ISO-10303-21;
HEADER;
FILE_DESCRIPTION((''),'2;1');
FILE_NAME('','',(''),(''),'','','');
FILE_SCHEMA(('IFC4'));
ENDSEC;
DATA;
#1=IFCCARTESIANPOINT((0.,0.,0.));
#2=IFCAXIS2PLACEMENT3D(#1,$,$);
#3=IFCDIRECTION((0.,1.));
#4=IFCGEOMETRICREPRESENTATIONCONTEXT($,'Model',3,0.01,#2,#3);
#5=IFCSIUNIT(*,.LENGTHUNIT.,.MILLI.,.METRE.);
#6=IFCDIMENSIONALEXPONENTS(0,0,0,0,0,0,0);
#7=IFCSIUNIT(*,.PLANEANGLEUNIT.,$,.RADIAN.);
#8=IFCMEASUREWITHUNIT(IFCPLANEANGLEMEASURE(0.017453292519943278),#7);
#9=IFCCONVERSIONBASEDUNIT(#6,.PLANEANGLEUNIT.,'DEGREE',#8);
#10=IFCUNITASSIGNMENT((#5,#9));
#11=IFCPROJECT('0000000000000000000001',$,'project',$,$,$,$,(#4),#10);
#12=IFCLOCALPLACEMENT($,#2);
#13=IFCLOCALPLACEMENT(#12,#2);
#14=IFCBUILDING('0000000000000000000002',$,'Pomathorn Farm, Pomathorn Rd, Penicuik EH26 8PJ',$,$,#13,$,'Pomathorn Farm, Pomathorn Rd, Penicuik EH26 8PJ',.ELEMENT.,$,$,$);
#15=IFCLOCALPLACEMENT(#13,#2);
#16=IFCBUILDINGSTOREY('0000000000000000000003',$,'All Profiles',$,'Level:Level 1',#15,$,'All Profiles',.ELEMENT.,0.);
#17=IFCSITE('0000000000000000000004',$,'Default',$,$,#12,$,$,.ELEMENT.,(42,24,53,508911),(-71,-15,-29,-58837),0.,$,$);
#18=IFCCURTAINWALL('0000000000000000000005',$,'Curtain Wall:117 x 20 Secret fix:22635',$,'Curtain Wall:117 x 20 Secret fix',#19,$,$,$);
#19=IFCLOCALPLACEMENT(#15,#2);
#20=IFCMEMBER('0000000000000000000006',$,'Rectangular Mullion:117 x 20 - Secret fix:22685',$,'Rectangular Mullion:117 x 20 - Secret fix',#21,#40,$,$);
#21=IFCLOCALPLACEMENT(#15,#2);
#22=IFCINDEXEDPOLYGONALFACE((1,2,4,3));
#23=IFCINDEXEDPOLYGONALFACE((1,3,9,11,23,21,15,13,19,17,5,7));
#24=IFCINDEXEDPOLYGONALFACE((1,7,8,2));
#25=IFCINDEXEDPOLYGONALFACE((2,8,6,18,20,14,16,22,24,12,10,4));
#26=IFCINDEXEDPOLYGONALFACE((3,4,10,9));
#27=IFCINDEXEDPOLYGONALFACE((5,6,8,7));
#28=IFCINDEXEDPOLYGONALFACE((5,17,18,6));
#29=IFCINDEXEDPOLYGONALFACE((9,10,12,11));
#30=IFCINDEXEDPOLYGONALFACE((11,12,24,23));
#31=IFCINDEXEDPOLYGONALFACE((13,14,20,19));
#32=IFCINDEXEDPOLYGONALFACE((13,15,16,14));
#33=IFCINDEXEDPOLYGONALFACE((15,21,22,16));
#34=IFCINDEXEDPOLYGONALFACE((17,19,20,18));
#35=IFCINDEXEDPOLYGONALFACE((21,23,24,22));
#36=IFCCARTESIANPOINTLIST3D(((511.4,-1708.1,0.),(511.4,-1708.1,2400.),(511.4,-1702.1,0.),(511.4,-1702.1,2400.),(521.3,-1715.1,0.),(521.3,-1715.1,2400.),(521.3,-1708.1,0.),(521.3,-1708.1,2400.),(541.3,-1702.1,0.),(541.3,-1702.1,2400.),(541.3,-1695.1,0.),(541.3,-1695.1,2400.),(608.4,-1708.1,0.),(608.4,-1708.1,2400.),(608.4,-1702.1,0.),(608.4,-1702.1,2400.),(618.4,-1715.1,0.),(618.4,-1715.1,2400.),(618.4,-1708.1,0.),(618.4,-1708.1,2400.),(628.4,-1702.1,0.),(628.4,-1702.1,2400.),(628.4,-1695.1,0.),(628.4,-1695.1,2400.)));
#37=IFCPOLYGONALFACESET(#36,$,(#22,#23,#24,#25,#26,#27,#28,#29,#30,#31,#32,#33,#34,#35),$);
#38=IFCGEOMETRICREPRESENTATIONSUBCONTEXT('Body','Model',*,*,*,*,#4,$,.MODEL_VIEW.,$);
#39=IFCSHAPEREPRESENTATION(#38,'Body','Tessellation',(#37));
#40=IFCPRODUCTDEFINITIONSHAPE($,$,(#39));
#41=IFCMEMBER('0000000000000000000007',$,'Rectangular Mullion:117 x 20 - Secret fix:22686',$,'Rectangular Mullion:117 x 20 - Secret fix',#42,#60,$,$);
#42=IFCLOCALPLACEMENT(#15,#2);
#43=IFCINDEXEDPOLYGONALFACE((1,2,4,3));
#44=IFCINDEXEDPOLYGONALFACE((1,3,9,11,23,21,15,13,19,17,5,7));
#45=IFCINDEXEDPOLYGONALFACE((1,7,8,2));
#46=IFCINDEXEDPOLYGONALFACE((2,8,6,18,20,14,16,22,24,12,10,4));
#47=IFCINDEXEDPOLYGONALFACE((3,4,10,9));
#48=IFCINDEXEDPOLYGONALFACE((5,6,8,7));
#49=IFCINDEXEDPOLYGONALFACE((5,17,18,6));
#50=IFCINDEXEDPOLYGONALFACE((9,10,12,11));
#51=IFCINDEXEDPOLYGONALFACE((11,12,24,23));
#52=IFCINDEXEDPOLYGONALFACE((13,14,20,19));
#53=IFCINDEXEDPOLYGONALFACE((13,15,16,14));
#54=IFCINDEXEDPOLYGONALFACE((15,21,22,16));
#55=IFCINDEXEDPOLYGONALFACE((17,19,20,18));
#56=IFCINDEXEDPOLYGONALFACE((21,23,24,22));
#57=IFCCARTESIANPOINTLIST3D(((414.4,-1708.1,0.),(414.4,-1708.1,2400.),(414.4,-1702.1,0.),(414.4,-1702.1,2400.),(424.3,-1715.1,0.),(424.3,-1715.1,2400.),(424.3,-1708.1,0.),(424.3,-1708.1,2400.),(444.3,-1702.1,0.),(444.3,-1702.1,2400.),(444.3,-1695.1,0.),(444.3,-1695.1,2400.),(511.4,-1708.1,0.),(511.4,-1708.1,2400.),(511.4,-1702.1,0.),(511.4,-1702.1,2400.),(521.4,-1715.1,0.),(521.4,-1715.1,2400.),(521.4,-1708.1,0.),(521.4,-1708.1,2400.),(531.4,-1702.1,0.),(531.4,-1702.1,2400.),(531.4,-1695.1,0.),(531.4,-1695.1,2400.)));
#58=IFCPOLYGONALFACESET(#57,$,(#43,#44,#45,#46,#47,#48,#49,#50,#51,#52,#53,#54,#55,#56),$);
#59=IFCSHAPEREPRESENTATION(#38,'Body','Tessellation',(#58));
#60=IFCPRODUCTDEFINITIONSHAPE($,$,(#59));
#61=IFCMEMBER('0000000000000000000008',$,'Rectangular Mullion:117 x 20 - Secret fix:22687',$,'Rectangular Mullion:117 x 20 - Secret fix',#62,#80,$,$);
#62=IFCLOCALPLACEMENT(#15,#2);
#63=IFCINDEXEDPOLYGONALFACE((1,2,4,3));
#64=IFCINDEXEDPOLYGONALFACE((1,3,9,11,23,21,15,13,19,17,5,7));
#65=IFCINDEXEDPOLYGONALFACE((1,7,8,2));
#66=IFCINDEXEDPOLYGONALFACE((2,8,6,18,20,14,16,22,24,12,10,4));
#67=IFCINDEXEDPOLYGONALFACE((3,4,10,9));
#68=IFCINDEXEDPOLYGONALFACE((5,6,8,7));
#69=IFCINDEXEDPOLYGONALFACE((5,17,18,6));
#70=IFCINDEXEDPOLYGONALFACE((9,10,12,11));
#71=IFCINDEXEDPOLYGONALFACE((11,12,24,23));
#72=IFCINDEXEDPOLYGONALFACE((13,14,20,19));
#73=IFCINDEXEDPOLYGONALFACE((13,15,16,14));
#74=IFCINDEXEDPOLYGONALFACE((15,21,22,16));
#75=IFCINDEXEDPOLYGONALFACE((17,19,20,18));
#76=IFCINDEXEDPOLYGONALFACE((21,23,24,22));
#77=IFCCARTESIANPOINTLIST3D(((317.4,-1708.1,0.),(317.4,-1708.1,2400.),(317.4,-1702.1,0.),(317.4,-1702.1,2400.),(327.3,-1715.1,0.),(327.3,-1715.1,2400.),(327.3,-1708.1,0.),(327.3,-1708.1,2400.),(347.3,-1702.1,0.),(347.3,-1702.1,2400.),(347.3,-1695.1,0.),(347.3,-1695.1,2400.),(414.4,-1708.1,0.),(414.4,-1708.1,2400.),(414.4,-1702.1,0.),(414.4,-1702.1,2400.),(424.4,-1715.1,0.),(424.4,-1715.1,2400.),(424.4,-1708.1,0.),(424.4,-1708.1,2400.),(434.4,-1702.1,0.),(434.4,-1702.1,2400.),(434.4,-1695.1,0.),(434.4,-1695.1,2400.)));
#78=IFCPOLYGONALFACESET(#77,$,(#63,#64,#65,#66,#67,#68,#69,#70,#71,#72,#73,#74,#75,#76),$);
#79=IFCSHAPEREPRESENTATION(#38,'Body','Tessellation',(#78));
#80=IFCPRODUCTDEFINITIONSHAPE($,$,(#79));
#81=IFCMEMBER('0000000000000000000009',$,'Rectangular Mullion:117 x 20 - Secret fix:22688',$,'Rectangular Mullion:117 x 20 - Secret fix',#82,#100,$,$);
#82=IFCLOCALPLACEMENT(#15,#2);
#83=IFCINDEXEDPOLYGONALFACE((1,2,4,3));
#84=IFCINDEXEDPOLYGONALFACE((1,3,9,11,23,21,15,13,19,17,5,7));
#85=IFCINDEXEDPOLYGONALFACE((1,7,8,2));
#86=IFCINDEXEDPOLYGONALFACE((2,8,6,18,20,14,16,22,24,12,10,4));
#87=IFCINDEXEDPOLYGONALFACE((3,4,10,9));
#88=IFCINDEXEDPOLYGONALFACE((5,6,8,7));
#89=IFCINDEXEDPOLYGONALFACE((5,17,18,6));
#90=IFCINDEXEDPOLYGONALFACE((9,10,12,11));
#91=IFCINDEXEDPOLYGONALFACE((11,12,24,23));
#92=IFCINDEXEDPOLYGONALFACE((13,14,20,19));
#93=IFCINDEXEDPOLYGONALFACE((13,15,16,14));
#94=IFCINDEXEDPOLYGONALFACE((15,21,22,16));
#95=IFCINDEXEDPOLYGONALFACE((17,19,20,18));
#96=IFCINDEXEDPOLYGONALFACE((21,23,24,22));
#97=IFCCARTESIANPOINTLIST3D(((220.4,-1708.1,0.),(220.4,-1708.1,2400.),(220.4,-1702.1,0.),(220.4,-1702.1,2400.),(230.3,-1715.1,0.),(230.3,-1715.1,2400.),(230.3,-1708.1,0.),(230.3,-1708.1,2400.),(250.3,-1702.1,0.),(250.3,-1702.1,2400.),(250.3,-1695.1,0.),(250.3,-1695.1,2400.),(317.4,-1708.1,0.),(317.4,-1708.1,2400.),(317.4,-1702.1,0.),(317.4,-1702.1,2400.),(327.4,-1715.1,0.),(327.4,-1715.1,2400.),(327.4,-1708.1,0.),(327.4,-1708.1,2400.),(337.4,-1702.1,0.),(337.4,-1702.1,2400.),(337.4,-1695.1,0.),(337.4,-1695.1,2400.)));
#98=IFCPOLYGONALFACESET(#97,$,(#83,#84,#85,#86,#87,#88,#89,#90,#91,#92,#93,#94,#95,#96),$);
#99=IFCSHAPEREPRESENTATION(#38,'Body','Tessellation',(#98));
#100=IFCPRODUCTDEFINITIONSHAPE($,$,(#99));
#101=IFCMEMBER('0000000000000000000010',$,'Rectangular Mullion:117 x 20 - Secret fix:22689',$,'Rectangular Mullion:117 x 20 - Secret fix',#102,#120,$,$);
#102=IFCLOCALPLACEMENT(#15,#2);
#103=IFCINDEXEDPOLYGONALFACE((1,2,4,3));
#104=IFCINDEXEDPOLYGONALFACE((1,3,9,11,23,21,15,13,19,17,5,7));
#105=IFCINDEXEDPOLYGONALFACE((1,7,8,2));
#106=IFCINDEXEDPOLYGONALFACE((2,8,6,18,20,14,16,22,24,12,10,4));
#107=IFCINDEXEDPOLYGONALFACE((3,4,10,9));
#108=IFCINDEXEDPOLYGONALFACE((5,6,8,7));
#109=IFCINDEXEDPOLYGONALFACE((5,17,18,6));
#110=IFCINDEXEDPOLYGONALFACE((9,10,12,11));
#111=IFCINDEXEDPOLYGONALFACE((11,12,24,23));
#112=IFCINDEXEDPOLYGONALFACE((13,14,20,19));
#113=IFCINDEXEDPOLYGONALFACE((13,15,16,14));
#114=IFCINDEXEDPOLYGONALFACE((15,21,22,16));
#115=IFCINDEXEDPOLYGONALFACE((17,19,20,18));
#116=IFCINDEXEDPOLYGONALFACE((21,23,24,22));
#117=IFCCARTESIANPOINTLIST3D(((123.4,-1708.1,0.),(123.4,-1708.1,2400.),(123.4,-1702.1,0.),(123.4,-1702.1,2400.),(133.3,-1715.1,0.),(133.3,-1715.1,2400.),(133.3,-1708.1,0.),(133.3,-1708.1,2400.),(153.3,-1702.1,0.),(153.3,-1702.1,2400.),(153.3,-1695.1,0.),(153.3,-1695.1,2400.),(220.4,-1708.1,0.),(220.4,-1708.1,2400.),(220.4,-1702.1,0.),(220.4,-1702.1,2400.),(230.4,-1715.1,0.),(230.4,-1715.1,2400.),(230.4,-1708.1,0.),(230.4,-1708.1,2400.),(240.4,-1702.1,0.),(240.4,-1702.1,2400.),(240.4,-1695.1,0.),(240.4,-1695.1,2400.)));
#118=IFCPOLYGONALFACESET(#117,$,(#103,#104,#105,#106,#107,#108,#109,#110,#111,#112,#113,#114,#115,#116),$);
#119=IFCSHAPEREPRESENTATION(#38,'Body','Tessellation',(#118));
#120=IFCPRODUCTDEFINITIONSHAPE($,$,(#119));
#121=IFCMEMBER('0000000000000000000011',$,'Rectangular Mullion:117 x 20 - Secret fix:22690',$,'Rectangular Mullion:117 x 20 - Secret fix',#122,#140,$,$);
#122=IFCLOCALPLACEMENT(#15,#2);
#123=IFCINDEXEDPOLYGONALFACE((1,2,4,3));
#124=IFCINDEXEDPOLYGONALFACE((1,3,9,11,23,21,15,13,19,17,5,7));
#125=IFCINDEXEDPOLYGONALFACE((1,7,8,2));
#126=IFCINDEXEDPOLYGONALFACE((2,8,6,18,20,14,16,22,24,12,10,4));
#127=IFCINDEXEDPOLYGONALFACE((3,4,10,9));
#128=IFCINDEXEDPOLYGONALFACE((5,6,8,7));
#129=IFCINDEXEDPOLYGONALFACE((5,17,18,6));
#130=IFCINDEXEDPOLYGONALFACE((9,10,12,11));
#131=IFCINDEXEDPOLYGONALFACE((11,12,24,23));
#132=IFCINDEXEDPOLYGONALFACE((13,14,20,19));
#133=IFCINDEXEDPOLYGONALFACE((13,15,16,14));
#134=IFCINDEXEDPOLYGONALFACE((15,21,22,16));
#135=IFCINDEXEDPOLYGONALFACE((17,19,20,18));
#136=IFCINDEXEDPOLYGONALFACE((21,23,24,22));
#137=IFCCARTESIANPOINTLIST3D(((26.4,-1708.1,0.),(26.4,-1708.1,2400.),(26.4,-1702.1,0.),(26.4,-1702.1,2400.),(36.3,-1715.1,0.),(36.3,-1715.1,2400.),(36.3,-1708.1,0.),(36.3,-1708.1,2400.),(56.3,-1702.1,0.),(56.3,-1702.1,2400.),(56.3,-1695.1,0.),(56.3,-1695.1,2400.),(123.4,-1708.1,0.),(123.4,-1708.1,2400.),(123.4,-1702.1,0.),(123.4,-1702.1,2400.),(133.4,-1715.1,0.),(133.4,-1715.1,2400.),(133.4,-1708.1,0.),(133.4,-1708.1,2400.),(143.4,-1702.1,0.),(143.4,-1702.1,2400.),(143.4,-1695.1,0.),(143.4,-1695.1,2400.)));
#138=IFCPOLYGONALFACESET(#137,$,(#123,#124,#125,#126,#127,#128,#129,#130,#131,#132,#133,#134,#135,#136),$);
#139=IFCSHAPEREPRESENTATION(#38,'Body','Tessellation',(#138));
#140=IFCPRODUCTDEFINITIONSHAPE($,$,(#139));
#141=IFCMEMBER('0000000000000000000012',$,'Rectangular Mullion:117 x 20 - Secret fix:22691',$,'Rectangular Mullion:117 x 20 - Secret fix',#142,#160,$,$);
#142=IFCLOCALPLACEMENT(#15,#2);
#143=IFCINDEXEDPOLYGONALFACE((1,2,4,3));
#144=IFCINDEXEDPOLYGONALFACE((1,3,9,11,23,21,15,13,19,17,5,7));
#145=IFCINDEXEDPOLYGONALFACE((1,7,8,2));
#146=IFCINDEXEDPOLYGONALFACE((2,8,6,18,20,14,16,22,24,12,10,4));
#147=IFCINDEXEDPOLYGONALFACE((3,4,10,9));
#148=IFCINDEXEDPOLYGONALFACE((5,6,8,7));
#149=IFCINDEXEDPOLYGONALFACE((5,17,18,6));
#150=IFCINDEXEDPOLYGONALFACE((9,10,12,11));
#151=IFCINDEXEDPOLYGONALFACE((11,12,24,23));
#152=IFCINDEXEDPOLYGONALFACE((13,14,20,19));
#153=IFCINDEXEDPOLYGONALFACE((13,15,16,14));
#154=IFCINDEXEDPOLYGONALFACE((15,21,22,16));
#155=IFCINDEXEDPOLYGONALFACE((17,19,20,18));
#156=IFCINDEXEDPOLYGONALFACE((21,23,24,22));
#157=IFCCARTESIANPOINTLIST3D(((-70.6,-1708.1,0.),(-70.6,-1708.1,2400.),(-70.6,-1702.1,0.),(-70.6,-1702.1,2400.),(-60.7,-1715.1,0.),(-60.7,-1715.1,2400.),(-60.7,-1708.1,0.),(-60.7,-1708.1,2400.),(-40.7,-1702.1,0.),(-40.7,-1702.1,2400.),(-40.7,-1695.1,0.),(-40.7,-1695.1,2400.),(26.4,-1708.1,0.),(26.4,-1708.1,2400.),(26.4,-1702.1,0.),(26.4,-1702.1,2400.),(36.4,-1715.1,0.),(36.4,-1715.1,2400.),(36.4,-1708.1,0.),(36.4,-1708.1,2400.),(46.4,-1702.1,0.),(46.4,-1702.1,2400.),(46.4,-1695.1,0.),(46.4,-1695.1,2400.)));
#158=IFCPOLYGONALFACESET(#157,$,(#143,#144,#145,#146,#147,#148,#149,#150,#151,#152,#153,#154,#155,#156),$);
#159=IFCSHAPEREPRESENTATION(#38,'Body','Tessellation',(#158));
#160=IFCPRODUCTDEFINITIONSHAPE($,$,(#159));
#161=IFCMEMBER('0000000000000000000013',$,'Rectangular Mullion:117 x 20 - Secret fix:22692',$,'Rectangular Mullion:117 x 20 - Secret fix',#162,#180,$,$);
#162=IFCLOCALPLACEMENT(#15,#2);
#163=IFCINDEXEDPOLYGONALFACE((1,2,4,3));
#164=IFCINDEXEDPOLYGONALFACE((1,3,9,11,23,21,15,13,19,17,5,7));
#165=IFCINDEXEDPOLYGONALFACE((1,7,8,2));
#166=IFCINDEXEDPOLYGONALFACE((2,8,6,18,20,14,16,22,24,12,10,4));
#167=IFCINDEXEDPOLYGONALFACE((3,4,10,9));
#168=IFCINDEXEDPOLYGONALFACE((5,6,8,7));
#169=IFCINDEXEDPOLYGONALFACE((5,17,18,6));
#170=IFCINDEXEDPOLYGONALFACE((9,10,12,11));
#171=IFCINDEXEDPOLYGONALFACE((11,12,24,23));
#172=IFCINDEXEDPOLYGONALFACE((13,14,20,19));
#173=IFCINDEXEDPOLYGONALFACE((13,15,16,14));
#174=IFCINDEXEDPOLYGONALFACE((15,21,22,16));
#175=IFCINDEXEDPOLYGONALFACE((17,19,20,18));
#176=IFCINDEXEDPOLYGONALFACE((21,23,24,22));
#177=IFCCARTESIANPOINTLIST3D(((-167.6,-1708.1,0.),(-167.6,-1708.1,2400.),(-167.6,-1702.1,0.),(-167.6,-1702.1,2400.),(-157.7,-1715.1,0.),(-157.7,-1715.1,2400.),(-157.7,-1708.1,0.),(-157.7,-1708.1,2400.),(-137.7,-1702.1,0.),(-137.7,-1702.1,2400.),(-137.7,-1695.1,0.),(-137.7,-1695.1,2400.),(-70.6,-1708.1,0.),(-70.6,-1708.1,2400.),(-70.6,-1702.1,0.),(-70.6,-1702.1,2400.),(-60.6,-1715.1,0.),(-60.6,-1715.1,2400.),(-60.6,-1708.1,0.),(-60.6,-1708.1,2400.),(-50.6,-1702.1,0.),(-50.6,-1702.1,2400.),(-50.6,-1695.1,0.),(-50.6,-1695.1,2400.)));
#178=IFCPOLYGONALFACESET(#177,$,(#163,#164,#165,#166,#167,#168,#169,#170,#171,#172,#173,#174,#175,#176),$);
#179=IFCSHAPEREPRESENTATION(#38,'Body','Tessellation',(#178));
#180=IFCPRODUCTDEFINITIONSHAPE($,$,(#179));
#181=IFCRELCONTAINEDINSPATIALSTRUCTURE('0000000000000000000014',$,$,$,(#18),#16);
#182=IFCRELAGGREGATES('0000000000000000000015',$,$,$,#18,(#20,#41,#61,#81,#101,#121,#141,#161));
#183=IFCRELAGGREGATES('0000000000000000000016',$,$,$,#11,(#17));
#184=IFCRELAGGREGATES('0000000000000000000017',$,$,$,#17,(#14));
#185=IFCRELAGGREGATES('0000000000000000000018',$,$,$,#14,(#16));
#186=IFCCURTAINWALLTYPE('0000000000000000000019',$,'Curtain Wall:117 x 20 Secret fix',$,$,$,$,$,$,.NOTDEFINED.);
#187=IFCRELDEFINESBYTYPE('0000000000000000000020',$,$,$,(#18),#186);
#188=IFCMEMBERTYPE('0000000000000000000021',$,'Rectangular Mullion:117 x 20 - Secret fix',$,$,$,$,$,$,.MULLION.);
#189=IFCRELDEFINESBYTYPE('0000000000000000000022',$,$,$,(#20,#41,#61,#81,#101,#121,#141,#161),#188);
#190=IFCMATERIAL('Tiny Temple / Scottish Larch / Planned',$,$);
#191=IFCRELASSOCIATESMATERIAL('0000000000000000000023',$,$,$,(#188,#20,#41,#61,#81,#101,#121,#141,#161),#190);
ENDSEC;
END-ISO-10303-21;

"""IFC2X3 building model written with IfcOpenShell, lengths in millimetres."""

from ifc_helpers import new_model, entity, si_unit, converted_unit, direction, frame, origin, place, context, subcontext, project, spatial, polyline, outline, extrude, source, transform, mapped, material, type_object, type_shapes, element, aggregate, save


model = new_model("IFC2X3")

# Units and contexts
model_context = context("Model", 3, precision=0.01, world=origin(), true_north=direction((0.0, 1.0)))
body_context = subcontext(model_context, "Body", "Model", "MODEL_VIEW")
ifc_project = project(units=[si_unit("LENGTHUNIT", "METRE", prefix="MILLI"), converted_unit("PLANEANGLEUNIT", "DEGREE", entity("IfcPlaneAngleMeasure", 0.017453292519943278), si_unit("PLANEANGLEUNIT", "RADIAN"), dimensions=[0, 0, 0, 0, 0, 0, 0])], contexts=[model_context])

# Site, building, storey
site_placement = place(None, origin())
site = spatial("IfcSite", under=ifc_project, at=site_placement, Name="Default", CompositionType="ELEMENT", RefLatitude=(42, 24, 53, 508911), RefLongitude=(-71, -15, -29, -58837), RefElevation=0.0)
building_placement = place(site_placement, origin())
building = spatial("IfcBuilding", under=site, at=building_placement, Name="Pomathorn Farm, Pomathorn Rd, Penicuik EH26 8PJ", LongName="Pomathorn Farm, Pomathorn Rd, Penicuik EH26 8PJ", CompositionType="ELEMENT")
storey_placement = place(building_placement, origin())
storey = spatial("IfcBuildingStorey", under=building, at=storey_placement, Name="All Profiles", ObjectType="Level:Level 1", LongName="All Profiles", CompositionType="ELEMENT", Elevation=0.0)

# Curtain wall, members
curtain_wall_type_1 = type_object("IfcCurtainWallType", Name="Curtain Wall:117 x 20 Secret fix", PredefinedType="NOTDEFINED")
curtain_wall_1_placement = place(storey_placement, origin())
curtain_wall_1 = element("IfcCurtainWall", 1, at=curtain_wall_1_placement, inside=storey, type_object=curtain_wall_type_1, Name="Curtain Wall:117 x 20 Secret fix:22635", ObjectType="Curtain Wall:117 x 20 Secret fix")
ifc_material = material(Name="Tiny Temple / Scottish Larch / Planned")
member_type_1 = type_object("IfcMemberType", Name="Rectangular Mullion:117 x 20 - Secret fix", PredefinedType="MULLION", material=ifc_material)
shared_shape_1 = source(origin(), body_context, "Body", "SweptSolid", [
    extrude(outline(polyline([(-3.0, -60.2), (3.0, -60.2), (3.0, -30.2), (10.0, -30.2), (10.0, 56.8), (3.0, 56.8), (3.0, 36.8), (-3.0, 36.8), (-3.0, 46.8), (-10.0, 46.8), (-10.0, -50.2), (-3.0, -50.2), (-3.0, -60.2)])), frame((-56.8, -10.0, -2400.0), z_axis=(0.0, 0.0, 1.0), x_axis=(0.0, -1.0, 0.0)), (0.0, 0.0, 1.0), 2400.0),
])
type_shapes(member_type_1, [shared_shape_1])
member_1_placement = place(curtain_wall_1_placement, frame((628.4, -1715.1, 0.0), z_axis=(0.0, 0.0, -1.0), x_axis=(1.0, 0.0, 0.0)))
member_1 = element("IfcMember", 2, at=member_1_placement, type_object=member_type_1, material=ifc_material, Name="Rectangular Mullion:117 x 20 - Secret fix:22685", ObjectType="Rectangular Mullion:117 x 20 - Secret fix", context=body_context, shape_type="MappedRepresentation", body=[
    mapped(shared_shape_1, transform((0.0, 0.0, 0.0), scale=1.0)),
])
member_2_placement = place(curtain_wall_1_placement, frame((531.4, -1715.1, 0.0), z_axis=(0.0, 0.0, -1.0), x_axis=(1.0, 0.0, 0.0)))
member_2 = element("IfcMember", 3, at=member_2_placement, type_object=member_type_1, material=ifc_material, Name="Rectangular Mullion:117 x 20 - Secret fix:22686", ObjectType="Rectangular Mullion:117 x 20 - Secret fix", context=body_context, shape_type="MappedRepresentation", body=[
    mapped(shared_shape_1, transform((0.0, 0.0, 0.0), scale=1.0)),
])
member_3_placement = place(curtain_wall_1_placement, frame((434.4, -1715.1, 0.0), z_axis=(0.0, 0.0, -1.0), x_axis=(1.0, 0.0, 0.0)))
member_3 = element("IfcMember", 4, at=member_3_placement, type_object=member_type_1, material=ifc_material, Name="Rectangular Mullion:117 x 20 - Secret fix:22687", ObjectType="Rectangular Mullion:117 x 20 - Secret fix", context=body_context, shape_type="MappedRepresentation", body=[
    mapped(shared_shape_1, transform((0.0, 0.0, 0.0), scale=1.0)),
])
member_4_placement = place(curtain_wall_1_placement, frame((337.4, -1715.1, 0.0), z_axis=(0.0, 0.0, -1.0), x_axis=(1.0, 0.0, 0.0)))
member_4 = element("IfcMember", 5, at=member_4_placement, type_object=member_type_1, material=ifc_material, Name="Rectangular Mullion:117 x 20 - Secret fix:22688", ObjectType="Rectangular Mullion:117 x 20 - Secret fix", context=body_context, shape_type="MappedRepresentation", body=[
    mapped(shared_shape_1, transform((0.0, 0.0, 0.0), scale=1.0)),
])
member_5_placement = place(curtain_wall_1_placement, frame((240.4, -1715.1, 0.0), z_axis=(0.0, 0.0, -1.0), x_axis=(1.0, 0.0, 0.0)))
member_5 = element("IfcMember", 6, at=member_5_placement, type_object=member_type_1, material=ifc_material, Name="Rectangular Mullion:117 x 20 - Secret fix:22689", ObjectType="Rectangular Mullion:117 x 20 - Secret fix", context=body_context, shape_type="MappedRepresentation", body=[
    mapped(shared_shape_1, transform((0.0, 0.0, 0.0), scale=1.0)),
])
member_6_placement = place(curtain_wall_1_placement, frame((143.4, -1715.1, 0.0), z_axis=(0.0, 0.0, -1.0), x_axis=(1.0, 0.0, 0.0)))
member_6 = element("IfcMember", 7, at=member_6_placement, type_object=member_type_1, material=ifc_material, Name="Rectangular Mullion:117 x 20 - Secret fix:22690", ObjectType="Rectangular Mullion:117 x 20 - Secret fix", context=body_context, shape_type="MappedRepresentation", body=[
    mapped(shared_shape_1, transform((0.0, 0.0, 0.0), scale=1.0)),
])
member_7_placement = place(curtain_wall_1_placement, frame((46.4, -1715.1, 0.0), z_axis=(0.0, 0.0, -1.0), x_axis=(1.0, 0.0, 0.0)))
member_7 = element("IfcMember", 8, at=member_7_placement, type_object=member_type_1, material=ifc_material, Name="Rectangular Mullion:117 x 20 - Secret fix:22691", ObjectType="Rectangular Mullion:117 x 20 - Secret fix", context=body_context, shape_type="MappedRepresentation", body=[
    mapped(shared_shape_1, transform((0.0, 0.0, 0.0), scale=1.0)),
])
member_8_placement = place(curtain_wall_1_placement, frame((-50.6, -1715.1, 0.0), z_axis=(0.0, 0.0, -1.0), x_axis=(1.0, 0.0, 0.0)))
member_8 = element("IfcMember", 9, at=member_8_placement, type_object=member_type_1, material=ifc_material, Name="Rectangular Mullion:117 x 20 - Secret fix:22692", ObjectType="Rectangular Mullion:117 x 20 - Secret fix", context=body_context, shape_type="MappedRepresentation", body=[
    mapped(shared_shape_1, transform((0.0, 0.0, 0.0), scale=1.0)),
])
aggregate(curtain_wall_1, [member_1, member_2, member_3, member_4, member_5, member_6, member_7, member_8])

save(model, "model.ifc")
